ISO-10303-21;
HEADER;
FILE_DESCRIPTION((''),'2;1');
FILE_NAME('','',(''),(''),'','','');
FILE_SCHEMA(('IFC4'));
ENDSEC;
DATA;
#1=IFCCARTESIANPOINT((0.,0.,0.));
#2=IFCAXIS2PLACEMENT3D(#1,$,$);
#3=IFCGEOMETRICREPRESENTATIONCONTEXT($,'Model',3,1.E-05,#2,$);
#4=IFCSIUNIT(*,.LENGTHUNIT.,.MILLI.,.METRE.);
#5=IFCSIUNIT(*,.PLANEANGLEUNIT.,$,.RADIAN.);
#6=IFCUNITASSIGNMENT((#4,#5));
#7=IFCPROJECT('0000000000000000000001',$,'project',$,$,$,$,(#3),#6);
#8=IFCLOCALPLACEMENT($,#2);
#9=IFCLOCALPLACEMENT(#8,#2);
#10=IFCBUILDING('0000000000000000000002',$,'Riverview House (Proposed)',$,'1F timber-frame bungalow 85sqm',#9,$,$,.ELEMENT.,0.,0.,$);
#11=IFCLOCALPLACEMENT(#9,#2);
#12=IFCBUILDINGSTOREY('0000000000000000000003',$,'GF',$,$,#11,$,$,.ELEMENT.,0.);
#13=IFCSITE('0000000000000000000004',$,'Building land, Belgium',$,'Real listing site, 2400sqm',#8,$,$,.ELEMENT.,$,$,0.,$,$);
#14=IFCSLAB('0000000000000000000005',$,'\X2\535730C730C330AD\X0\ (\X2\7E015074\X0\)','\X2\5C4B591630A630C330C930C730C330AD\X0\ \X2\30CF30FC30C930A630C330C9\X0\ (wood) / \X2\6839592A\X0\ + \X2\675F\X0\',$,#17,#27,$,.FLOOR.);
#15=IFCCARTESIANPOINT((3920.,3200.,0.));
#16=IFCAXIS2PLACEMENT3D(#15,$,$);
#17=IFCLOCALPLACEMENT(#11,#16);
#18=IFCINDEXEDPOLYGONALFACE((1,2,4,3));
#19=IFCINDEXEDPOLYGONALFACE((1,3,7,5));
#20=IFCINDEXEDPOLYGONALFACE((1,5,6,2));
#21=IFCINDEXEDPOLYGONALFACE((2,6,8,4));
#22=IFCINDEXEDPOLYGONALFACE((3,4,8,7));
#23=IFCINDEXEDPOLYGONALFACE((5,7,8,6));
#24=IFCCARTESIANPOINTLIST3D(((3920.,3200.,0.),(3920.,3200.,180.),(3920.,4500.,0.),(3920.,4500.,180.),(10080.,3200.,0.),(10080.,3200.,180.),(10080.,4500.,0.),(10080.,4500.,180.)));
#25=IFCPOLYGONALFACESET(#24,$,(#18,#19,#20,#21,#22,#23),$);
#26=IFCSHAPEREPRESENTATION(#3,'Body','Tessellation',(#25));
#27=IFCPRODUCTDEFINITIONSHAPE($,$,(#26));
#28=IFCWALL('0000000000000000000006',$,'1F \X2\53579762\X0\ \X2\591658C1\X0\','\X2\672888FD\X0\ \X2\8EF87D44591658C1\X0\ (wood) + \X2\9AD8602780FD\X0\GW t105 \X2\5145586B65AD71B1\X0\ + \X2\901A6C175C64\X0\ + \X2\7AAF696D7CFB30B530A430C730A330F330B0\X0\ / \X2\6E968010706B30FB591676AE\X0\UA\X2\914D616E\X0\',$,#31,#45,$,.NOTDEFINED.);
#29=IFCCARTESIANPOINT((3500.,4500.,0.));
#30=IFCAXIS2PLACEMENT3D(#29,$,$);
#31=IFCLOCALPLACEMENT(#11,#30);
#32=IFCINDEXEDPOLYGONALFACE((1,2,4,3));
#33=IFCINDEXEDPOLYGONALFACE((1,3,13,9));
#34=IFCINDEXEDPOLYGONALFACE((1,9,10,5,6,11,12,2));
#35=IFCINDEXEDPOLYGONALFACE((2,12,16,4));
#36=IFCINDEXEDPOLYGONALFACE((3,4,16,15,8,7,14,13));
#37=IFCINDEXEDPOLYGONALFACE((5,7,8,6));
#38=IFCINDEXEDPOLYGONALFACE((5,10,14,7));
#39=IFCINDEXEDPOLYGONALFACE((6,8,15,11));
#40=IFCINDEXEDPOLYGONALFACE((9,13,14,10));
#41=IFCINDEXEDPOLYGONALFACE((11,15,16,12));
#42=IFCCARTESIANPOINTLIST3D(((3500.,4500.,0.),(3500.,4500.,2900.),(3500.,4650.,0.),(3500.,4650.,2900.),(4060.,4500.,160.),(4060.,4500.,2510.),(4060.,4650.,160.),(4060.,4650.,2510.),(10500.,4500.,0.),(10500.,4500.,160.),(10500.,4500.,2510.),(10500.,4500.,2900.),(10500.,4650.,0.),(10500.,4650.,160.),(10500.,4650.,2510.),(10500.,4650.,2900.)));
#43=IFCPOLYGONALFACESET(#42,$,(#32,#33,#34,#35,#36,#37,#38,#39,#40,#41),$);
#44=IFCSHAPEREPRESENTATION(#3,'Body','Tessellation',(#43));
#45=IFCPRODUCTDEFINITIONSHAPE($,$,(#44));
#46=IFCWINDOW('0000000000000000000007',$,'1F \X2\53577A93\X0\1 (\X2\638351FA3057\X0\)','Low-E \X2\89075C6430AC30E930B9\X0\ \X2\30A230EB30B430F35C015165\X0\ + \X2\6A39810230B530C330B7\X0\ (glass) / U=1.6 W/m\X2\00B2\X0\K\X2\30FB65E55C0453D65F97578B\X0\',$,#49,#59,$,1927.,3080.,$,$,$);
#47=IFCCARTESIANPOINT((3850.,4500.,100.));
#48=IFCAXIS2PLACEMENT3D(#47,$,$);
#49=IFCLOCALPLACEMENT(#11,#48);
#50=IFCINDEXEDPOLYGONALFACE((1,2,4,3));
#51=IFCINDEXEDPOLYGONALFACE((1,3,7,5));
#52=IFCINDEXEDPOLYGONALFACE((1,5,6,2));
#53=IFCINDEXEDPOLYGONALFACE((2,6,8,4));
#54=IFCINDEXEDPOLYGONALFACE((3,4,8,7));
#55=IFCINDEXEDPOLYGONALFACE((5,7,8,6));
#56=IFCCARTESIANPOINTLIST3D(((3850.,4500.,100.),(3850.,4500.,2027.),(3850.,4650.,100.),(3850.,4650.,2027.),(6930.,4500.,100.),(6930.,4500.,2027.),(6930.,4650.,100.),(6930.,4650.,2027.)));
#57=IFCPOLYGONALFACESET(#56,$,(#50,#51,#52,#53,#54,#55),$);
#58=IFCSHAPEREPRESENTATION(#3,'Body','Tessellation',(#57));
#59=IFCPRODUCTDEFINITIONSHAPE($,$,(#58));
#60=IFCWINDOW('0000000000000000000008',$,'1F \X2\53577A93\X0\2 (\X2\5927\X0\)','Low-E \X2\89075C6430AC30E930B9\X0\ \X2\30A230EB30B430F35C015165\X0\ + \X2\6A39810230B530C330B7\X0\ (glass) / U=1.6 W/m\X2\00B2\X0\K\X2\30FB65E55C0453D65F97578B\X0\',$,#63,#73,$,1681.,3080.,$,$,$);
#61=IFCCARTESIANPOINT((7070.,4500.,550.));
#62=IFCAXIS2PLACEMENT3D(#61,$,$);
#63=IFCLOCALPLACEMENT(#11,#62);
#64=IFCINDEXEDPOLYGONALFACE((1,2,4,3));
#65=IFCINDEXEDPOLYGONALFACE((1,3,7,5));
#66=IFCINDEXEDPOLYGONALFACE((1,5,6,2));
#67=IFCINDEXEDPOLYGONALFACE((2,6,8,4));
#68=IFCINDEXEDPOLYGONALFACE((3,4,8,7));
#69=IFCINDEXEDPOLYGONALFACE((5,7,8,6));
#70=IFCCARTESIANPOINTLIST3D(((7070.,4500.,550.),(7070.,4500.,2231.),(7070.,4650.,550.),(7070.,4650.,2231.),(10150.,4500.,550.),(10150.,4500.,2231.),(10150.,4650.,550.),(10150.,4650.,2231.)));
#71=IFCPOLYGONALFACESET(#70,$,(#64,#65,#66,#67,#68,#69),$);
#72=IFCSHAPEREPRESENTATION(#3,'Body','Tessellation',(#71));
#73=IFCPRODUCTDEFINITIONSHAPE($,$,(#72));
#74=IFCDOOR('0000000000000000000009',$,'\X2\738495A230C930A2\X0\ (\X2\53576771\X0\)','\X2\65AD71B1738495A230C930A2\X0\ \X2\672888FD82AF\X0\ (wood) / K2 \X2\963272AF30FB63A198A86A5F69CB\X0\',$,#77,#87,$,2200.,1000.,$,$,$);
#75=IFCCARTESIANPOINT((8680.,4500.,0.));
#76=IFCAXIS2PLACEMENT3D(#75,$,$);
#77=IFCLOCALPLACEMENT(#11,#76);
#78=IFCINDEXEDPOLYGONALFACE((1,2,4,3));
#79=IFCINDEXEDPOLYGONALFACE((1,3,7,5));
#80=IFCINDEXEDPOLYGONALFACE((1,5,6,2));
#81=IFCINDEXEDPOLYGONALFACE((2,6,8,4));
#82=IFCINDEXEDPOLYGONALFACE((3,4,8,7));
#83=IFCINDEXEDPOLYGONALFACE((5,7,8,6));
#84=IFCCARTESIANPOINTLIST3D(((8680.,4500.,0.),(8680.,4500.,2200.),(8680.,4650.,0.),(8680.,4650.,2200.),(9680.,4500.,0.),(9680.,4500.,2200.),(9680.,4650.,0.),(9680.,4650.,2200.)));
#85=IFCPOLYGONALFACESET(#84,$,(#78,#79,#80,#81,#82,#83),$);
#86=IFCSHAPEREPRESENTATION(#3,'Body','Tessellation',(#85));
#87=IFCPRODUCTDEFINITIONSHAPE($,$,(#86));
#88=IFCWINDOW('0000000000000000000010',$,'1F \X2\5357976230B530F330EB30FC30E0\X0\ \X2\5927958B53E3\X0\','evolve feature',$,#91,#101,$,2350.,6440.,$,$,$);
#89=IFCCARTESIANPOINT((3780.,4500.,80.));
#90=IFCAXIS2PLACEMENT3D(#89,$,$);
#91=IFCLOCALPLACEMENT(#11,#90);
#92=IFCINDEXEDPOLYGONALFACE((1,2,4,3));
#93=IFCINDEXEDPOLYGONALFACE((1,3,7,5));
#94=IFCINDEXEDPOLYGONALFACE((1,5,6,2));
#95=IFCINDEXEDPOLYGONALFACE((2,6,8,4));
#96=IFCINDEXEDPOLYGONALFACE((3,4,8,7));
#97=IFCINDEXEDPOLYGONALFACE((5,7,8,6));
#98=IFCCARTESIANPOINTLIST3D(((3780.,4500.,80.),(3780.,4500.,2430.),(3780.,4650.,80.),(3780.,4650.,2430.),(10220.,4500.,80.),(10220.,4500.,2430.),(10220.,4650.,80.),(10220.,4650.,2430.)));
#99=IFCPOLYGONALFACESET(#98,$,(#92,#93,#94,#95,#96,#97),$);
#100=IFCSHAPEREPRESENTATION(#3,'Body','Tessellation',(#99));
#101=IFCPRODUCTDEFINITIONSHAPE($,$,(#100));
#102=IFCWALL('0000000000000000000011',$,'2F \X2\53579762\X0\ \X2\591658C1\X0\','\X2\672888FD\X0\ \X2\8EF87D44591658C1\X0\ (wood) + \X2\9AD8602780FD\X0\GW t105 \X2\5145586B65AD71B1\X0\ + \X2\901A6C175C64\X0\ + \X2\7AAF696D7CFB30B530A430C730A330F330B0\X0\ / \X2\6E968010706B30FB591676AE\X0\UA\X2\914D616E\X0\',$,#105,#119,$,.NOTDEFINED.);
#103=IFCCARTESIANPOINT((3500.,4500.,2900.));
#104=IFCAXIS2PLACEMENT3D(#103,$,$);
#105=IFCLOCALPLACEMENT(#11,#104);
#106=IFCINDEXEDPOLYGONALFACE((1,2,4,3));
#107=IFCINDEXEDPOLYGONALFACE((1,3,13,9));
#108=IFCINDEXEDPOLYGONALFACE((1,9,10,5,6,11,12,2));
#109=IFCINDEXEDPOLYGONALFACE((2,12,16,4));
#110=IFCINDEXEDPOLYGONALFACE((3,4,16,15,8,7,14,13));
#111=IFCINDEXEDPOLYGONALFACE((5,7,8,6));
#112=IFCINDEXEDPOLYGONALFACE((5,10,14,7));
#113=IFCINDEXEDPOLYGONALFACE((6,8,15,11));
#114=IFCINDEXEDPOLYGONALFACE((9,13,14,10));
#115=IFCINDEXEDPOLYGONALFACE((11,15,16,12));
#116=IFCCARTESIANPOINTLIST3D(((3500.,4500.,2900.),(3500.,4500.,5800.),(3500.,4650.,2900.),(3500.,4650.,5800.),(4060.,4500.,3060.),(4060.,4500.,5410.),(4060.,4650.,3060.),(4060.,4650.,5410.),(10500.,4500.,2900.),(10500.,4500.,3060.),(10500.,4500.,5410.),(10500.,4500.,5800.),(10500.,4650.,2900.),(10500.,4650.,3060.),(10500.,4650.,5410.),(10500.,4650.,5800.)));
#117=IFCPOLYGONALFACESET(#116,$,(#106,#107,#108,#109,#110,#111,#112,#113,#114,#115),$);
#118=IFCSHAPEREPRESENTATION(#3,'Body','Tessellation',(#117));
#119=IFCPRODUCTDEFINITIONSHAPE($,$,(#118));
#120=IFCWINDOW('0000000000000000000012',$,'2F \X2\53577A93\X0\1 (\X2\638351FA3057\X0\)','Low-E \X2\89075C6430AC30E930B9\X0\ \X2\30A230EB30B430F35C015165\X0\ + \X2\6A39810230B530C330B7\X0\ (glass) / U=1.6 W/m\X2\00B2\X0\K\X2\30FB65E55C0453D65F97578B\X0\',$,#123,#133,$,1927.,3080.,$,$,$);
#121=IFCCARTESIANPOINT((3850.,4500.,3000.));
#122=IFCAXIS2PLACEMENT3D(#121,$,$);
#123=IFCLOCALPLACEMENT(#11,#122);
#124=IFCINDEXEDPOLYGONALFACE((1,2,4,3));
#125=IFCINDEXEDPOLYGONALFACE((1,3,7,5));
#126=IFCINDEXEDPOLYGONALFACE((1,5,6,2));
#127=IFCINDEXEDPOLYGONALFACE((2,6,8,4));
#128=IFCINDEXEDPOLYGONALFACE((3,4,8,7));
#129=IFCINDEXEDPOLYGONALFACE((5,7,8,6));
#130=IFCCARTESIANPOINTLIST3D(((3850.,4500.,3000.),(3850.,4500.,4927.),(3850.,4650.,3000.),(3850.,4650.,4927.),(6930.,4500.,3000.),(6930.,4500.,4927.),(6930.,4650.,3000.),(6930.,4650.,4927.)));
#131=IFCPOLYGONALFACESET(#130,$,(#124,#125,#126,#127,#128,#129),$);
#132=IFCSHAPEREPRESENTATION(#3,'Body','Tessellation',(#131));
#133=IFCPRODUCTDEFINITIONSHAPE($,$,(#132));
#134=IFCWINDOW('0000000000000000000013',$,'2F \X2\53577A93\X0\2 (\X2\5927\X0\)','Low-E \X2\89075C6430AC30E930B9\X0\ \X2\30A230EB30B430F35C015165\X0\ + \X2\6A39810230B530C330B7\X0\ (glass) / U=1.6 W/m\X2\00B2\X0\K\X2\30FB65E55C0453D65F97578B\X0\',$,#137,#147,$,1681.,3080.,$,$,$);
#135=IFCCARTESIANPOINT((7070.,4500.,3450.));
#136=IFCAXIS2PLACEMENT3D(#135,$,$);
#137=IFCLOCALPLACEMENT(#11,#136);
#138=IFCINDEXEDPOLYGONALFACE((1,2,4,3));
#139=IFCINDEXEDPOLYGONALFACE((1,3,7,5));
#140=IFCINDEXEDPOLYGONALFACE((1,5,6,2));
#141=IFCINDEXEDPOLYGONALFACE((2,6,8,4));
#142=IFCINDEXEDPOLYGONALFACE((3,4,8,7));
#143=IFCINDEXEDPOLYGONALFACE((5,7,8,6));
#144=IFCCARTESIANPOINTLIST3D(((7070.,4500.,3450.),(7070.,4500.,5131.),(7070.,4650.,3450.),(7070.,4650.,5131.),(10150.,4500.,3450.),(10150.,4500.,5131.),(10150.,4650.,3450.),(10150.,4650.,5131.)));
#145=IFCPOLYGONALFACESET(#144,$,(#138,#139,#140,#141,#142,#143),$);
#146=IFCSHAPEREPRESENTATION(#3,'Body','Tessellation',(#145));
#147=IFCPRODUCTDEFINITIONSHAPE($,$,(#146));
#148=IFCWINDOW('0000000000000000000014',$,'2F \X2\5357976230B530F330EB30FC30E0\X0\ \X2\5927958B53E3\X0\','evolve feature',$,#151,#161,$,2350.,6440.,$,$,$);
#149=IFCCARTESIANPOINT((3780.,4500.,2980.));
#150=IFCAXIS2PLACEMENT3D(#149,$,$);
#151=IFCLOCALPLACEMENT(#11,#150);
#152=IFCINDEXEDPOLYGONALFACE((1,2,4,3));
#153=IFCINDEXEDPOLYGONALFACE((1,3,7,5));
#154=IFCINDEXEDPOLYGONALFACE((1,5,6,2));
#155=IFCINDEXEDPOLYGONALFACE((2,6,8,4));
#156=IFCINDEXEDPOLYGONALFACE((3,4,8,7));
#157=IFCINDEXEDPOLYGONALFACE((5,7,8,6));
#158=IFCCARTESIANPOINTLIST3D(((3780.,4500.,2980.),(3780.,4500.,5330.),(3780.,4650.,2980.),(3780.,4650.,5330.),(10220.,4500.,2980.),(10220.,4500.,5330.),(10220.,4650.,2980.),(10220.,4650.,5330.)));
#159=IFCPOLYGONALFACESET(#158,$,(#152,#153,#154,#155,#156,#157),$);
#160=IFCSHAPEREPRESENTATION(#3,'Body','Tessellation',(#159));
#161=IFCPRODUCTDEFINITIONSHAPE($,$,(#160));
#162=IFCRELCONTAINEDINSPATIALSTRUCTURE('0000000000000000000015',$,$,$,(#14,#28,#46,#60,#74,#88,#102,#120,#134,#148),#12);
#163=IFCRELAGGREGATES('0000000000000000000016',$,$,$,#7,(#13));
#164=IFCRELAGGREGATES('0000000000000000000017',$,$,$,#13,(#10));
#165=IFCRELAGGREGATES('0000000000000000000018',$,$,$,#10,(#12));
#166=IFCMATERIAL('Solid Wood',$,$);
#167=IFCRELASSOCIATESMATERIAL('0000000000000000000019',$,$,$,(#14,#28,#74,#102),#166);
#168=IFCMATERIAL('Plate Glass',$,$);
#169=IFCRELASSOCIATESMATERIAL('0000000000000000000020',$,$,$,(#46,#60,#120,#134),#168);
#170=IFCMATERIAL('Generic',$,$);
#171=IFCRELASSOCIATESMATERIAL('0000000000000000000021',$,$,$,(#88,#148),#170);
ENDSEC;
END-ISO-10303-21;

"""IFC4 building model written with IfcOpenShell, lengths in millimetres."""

from ifc_helpers import new_model, si_unit, frame, frame_2d, origin, place, context, project, spatial, rectangle, extrude, material, element, fill, save


model = new_model("IFC4")

# Units and contexts
model_context = context("Model", 3, precision=1e-05, world=origin())
ifc_project = project(units=[si_unit("LENGTHUNIT", "METRE", prefix="MILLI"), si_unit("PLANEANGLEUNIT", "RADIAN")], contexts=[model_context])

# Site, building, storey
site_placement = place(None, origin())
site = spatial("IfcSite", under=ifc_project, at=site_placement, Name="Building land, Belgium", ObjectType="Real listing site, 2400sqm", CompositionType="ELEMENT", RefElevation=0.0)
building_placement = place(site_placement, origin())
building = spatial("IfcBuilding", under=site, at=building_placement, Name="Riverview House (Proposed)", ObjectType="1F timber-frame bungalow 85sqm", CompositionType="ELEMENT", ElevationOfRefHeight=0.0, ElevationOfTerrain=0.0)
storey_placement = place(building_placement, origin())
storey = spatial("IfcBuildingStorey", under=building, at=storey_placement, Name="GF", CompositionType="ELEMENT", Elevation=0.0)

# Slab
ifc_material_1 = material(Name="Solid Wood")
slab_1_placement = place(storey_placement, frame((3920.0, 3200.0, 0.0)))
element("IfcSlab", 1, at=slab_1_placement, inside=storey, material=ifc_material_1, Name="南デッキ (縁側)", Description="屋外ウッドデッキ ハードウッド (wood) / 根太 + 束", PredefinedType="FLOOR", context=model_context, shape_type="SweptSolid", body=[
    extrude(rectangle(XDim=6160.0, YDim=1300.0, at=frame_2d((3080.0, 650.0))), frame((3920.0, 3200.0, 0.0)), (0.0, 0.0, 1.0), 180.0),
])
ifc_material_2 = material(Name="Generic")

# Wall, openings, windows, door
wall_1_placement = place(storey_placement, frame((3500.0, 4500.0, 0.0)))
wall_1 = element("IfcWall", 2, at=wall_1_placement, inside=storey, material=ifc_material_1, Name="1F 南面 外壁", Description="木製 軸組外壁 (wood) + 高性能GW t105 充填断熱 + 通気層 + 窯業系サイディング / 準耐火・外皮UA配慮", PredefinedType="NOTDEFINED", context=model_context, shape_type="SweptSolid", body=[
    extrude(rectangle(XDim=7000.0, YDim=150.0, at=frame_2d((3500.0, 75.0))), frame((3500.0, 4500.0, 0.0)), (0.0, 0.0, 1.0), 2900.0),
])
opening_1_placement = place(storey_placement, frame((3850.0, 4500.0, 100.0)))
opening_1 = element("IfcOpeningElement", 3, at=opening_1_placement, cuts=wall_1, PredefinedType="NOTDEFINED", context=model_context, shape_type="SweptSolid", body=[
    extrude(rectangle(XDim=3080.0, YDim=150.0, at=frame_2d((1540.0, 75.0))), frame((3850.0, 4500.0, 100.0)), (0.0, 0.0, 1.0), 1927.0),
])
opening_2_placement = place(storey_placement, frame((7070.0, 4500.0, 550.0)))
opening_2 = element("IfcOpeningElement", 4, at=opening_2_placement, cuts=wall_1, PredefinedType="NOTDEFINED", context=model_context, shape_type="SweptSolid", body=[
    extrude(rectangle(XDim=3080.0, YDim=150.0, at=frame_2d((1540.0, 75.0))), frame((7070.0, 4500.0, 550.0)), (0.0, 0.0, 1.0), 1681.0),
])
opening_3_placement = place(storey_placement, frame((8680.0, 4500.0, 0.0)))
opening_3 = element("IfcOpeningElement", 5, at=opening_3_placement, cuts=wall_1, PredefinedType="NOTDEFINED", context=model_context, shape_type="SweptSolid", body=[
    extrude(rectangle(XDim=1000.0, YDim=150.0, at=frame_2d((500.0, 75.0))), frame((8680.0, 4500.0, 0.0)), (0.0, 0.0, 1.0), 2200.0),
])
opening_4_placement = place(storey_placement, frame((3780.0, 4500.0, 80.0)))
opening_4 = element("IfcOpeningElement", 6, at=opening_4_placement, cuts=wall_1, PredefinedType="NOTDEFINED", context=model_context, shape_type="SweptSolid", body=[
    extrude(rectangle(XDim=6440.0, YDim=150.0, at=frame_2d((3220.0, 75.0))), frame((3780.0, 4500.0, 80.0)), (0.0, 0.0, 1.0), 2350.0),
])
ifc_material_3 = material(Name="Plate Glass")
window_1_placement = place(storey_placement, frame((3850.0, 4500.0, 100.0)))
window_1 = element("IfcWindow", 7, at=window_1_placement, inside=storey, material=ifc_material_3, Name="1F 南窓1 (掃出し)", Description="Low-E 複層ガラス アルゴン封入 + 樹脂サッシ (glass) / U=1.6 W/m²K・日射取得型", OverallHeight=1927.0, OverallWidth=3080.0, context=model_context, shape_type="SweptSolid", body=[
    extrude(rectangle(XDim=3080.0, YDim=150.0, at=frame_2d((1540.0, 75.0))), frame((3850.0, 4500.0, 100.0)), (0.0, 0.0, 1.0), 1927.0),
])
fill(opening_1, window_1)
window_2_placement = place(storey_placement, frame((7070.0, 4500.0, 550.0)))
window_2 = element("IfcWindow", 8, at=window_2_placement, inside=storey, material=ifc_material_3, Name="1F 南窓2 (大)", Description="Low-E 複層ガラス アルゴン封入 + 樹脂サッシ (glass) / U=1.6 W/m²K・日射取得型", OverallHeight=1681.0, OverallWidth=3080.0, context=model_context, shape_type="SweptSolid", body=[
    extrude(rectangle(XDim=3080.0, YDim=150.0, at=frame_2d((1540.0, 75.0))), frame((7070.0, 4500.0, 550.0)), (0.0, 0.0, 1.0), 1681.0),
])
fill(opening_2, window_2)
door_placement = place(storey_placement, frame((8680.0, 4500.0, 0.0)))
door = element("IfcDoor", 9, at=door_placement, inside=storey, material=ifc_material_1, Name="玄関ドア (南東)", Description="断熱玄関ドア 木製芯 (wood) / K2 防犯・採風機構", OverallHeight=2200.0, OverallWidth=1000.0, context=model_context, shape_type="SweptSolid", body=[
    extrude(rectangle(XDim=1000.0, YDim=150.0, at=frame_2d((500.0, 75.0))), frame((8680.0, 4500.0, 0.0)), (0.0, 0.0, 1.0), 2200.0),
])
fill(opening_3, door)
window_3_placement = place(storey_placement, frame((3780.0, 4500.0, 80.0)))
window_3 = element("IfcWindow", 10, at=window_3_placement, inside=storey, material=ifc_material_2, Name="1F 南面サンルーム 大開口", Description="evolve feature", OverallHeight=2350.0, OverallWidth=6440.0, context=model_context, shape_type="SweptSolid", body=[
    extrude(rectangle(XDim=6440.0, YDim=150.0, at=frame_2d((3220.0, 75.0))), frame((3780.0, 4500.0, 80.0)), (0.0, 0.0, 1.0), 2350.0),
])
fill(opening_4, window_3)

# Wall, openings, windows
wall_2_placement = place(storey_placement, frame((3500.0, 4500.0, 2900.0)))
wall_2 = element("IfcWall", 11, at=wall_2_placement, inside=storey, material=ifc_material_1, Name="2F 南面 外壁", Description="木製 軸組外壁 (wood) + 高性能GW t105 充填断熱 + 通気層 + 窯業系サイディング / 準耐火・外皮UA配慮", PredefinedType="NOTDEFINED", context=model_context, shape_type="SweptSolid", body=[
    extrude(rectangle(XDim=7000.0, YDim=150.0, at=frame_2d((3500.0, 75.0))), frame((3500.0, 4500.0, 2900.0)), (0.0, 0.0, 1.0), 2900.0),
])
opening_5_placement = place(storey_placement, frame((3850.0, 4500.0, 3000.0)))
opening_5 = element("IfcOpeningElement", 12, at=opening_5_placement, cuts=wall_2, PredefinedType="NOTDEFINED", context=model_context, shape_type="SweptSolid", body=[
    extrude(rectangle(XDim=3080.0, YDim=150.0, at=frame_2d((1540.0, 75.0))), frame((3850.0, 4500.0, 3000.0)), (0.0, 0.0, 1.0), 1927.0),
])
opening_6_placement = place(storey_placement, frame((7070.0, 4500.0, 3450.0)))
opening_6 = element("IfcOpeningElement", 13, at=opening_6_placement, cuts=wall_2, PredefinedType="NOTDEFINED", context=model_context, shape_type="SweptSolid", body=[
    extrude(rectangle(XDim=3080.0, YDim=150.0, at=frame_2d((1540.0, 75.0))), frame((7070.0, 4500.0, 3450.0)), (0.0, 0.0, 1.0), 1681.0),
])
opening_7_placement = place(storey_placement, frame((3780.0, 4500.0, 2980.0)))
opening_7 = element("IfcOpeningElement", 14, at=opening_7_placement, cuts=wall_2, PredefinedType="NOTDEFINED", context=model_context, shape_type="SweptSolid", body=[
    extrude(rectangle(XDim=6440.0, YDim=150.0, at=frame_2d((3220.0, 75.0))), frame((3780.0, 4500.0, 2980.0)), (0.0, 0.0, 1.0), 2350.0),
])
window_4_placement = place(storey_placement, frame((3850.0, 4500.0, 3000.0)))
window_4 = element("IfcWindow", 15, at=window_4_placement, inside=storey, material=ifc_material_3, Name="2F 南窓1 (掃出し)", Description="Low-E 複層ガラス アルゴン封入 + 樹脂サッシ (glass) / U=1.6 W/m²K・日射取得型", OverallHeight=1927.0, OverallWidth=3080.0, context=model_context, shape_type="SweptSolid", body=[
    extrude(rectangle(XDim=3080.0, YDim=150.0, at=frame_2d((1540.0, 75.0))), frame((3850.0, 4500.0, 3000.0)), (0.0, 0.0, 1.0), 1927.0),
])
fill(opening_5, window_4)
window_5_placement = place(storey_placement, frame((7070.0, 4500.0, 3450.0)))
window_5 = element("IfcWindow", 16, at=window_5_placement, inside=storey, material=ifc_material_3, Name="2F 南窓2 (大)", Description="Low-E 複層ガラス アルゴン封入 + 樹脂サッシ (glass) / U=1.6 W/m²K・日射取得型", OverallHeight=1681.0, OverallWidth=3080.0, context=model_context, shape_type="SweptSolid", body=[
    extrude(rectangle(XDim=3080.0, YDim=150.0, at=frame_2d((1540.0, 75.0))), frame((7070.0, 4500.0, 3450.0)), (0.0, 0.0, 1.0), 1681.0),
])
fill(opening_6, window_5)
window_6_placement = place(storey_placement, frame((3780.0, 4500.0, 2980.0)))
window_6 = element("IfcWindow", 17, at=window_6_placement, inside=storey, material=ifc_material_2, Name="2F 南面サンルーム 大開口", Description="evolve feature", OverallHeight=2350.0, OverallWidth=6440.0, context=model_context, shape_type="SweptSolid", body=[
    extrude(rectangle(XDim=6440.0, YDim=150.0, at=frame_2d((3220.0, 75.0))), frame((3780.0, 4500.0, 2980.0)), (0.0, 0.0, 1.0), 2350.0),
])
fill(opening_7, window_6)

save(model, "model.ifc")
